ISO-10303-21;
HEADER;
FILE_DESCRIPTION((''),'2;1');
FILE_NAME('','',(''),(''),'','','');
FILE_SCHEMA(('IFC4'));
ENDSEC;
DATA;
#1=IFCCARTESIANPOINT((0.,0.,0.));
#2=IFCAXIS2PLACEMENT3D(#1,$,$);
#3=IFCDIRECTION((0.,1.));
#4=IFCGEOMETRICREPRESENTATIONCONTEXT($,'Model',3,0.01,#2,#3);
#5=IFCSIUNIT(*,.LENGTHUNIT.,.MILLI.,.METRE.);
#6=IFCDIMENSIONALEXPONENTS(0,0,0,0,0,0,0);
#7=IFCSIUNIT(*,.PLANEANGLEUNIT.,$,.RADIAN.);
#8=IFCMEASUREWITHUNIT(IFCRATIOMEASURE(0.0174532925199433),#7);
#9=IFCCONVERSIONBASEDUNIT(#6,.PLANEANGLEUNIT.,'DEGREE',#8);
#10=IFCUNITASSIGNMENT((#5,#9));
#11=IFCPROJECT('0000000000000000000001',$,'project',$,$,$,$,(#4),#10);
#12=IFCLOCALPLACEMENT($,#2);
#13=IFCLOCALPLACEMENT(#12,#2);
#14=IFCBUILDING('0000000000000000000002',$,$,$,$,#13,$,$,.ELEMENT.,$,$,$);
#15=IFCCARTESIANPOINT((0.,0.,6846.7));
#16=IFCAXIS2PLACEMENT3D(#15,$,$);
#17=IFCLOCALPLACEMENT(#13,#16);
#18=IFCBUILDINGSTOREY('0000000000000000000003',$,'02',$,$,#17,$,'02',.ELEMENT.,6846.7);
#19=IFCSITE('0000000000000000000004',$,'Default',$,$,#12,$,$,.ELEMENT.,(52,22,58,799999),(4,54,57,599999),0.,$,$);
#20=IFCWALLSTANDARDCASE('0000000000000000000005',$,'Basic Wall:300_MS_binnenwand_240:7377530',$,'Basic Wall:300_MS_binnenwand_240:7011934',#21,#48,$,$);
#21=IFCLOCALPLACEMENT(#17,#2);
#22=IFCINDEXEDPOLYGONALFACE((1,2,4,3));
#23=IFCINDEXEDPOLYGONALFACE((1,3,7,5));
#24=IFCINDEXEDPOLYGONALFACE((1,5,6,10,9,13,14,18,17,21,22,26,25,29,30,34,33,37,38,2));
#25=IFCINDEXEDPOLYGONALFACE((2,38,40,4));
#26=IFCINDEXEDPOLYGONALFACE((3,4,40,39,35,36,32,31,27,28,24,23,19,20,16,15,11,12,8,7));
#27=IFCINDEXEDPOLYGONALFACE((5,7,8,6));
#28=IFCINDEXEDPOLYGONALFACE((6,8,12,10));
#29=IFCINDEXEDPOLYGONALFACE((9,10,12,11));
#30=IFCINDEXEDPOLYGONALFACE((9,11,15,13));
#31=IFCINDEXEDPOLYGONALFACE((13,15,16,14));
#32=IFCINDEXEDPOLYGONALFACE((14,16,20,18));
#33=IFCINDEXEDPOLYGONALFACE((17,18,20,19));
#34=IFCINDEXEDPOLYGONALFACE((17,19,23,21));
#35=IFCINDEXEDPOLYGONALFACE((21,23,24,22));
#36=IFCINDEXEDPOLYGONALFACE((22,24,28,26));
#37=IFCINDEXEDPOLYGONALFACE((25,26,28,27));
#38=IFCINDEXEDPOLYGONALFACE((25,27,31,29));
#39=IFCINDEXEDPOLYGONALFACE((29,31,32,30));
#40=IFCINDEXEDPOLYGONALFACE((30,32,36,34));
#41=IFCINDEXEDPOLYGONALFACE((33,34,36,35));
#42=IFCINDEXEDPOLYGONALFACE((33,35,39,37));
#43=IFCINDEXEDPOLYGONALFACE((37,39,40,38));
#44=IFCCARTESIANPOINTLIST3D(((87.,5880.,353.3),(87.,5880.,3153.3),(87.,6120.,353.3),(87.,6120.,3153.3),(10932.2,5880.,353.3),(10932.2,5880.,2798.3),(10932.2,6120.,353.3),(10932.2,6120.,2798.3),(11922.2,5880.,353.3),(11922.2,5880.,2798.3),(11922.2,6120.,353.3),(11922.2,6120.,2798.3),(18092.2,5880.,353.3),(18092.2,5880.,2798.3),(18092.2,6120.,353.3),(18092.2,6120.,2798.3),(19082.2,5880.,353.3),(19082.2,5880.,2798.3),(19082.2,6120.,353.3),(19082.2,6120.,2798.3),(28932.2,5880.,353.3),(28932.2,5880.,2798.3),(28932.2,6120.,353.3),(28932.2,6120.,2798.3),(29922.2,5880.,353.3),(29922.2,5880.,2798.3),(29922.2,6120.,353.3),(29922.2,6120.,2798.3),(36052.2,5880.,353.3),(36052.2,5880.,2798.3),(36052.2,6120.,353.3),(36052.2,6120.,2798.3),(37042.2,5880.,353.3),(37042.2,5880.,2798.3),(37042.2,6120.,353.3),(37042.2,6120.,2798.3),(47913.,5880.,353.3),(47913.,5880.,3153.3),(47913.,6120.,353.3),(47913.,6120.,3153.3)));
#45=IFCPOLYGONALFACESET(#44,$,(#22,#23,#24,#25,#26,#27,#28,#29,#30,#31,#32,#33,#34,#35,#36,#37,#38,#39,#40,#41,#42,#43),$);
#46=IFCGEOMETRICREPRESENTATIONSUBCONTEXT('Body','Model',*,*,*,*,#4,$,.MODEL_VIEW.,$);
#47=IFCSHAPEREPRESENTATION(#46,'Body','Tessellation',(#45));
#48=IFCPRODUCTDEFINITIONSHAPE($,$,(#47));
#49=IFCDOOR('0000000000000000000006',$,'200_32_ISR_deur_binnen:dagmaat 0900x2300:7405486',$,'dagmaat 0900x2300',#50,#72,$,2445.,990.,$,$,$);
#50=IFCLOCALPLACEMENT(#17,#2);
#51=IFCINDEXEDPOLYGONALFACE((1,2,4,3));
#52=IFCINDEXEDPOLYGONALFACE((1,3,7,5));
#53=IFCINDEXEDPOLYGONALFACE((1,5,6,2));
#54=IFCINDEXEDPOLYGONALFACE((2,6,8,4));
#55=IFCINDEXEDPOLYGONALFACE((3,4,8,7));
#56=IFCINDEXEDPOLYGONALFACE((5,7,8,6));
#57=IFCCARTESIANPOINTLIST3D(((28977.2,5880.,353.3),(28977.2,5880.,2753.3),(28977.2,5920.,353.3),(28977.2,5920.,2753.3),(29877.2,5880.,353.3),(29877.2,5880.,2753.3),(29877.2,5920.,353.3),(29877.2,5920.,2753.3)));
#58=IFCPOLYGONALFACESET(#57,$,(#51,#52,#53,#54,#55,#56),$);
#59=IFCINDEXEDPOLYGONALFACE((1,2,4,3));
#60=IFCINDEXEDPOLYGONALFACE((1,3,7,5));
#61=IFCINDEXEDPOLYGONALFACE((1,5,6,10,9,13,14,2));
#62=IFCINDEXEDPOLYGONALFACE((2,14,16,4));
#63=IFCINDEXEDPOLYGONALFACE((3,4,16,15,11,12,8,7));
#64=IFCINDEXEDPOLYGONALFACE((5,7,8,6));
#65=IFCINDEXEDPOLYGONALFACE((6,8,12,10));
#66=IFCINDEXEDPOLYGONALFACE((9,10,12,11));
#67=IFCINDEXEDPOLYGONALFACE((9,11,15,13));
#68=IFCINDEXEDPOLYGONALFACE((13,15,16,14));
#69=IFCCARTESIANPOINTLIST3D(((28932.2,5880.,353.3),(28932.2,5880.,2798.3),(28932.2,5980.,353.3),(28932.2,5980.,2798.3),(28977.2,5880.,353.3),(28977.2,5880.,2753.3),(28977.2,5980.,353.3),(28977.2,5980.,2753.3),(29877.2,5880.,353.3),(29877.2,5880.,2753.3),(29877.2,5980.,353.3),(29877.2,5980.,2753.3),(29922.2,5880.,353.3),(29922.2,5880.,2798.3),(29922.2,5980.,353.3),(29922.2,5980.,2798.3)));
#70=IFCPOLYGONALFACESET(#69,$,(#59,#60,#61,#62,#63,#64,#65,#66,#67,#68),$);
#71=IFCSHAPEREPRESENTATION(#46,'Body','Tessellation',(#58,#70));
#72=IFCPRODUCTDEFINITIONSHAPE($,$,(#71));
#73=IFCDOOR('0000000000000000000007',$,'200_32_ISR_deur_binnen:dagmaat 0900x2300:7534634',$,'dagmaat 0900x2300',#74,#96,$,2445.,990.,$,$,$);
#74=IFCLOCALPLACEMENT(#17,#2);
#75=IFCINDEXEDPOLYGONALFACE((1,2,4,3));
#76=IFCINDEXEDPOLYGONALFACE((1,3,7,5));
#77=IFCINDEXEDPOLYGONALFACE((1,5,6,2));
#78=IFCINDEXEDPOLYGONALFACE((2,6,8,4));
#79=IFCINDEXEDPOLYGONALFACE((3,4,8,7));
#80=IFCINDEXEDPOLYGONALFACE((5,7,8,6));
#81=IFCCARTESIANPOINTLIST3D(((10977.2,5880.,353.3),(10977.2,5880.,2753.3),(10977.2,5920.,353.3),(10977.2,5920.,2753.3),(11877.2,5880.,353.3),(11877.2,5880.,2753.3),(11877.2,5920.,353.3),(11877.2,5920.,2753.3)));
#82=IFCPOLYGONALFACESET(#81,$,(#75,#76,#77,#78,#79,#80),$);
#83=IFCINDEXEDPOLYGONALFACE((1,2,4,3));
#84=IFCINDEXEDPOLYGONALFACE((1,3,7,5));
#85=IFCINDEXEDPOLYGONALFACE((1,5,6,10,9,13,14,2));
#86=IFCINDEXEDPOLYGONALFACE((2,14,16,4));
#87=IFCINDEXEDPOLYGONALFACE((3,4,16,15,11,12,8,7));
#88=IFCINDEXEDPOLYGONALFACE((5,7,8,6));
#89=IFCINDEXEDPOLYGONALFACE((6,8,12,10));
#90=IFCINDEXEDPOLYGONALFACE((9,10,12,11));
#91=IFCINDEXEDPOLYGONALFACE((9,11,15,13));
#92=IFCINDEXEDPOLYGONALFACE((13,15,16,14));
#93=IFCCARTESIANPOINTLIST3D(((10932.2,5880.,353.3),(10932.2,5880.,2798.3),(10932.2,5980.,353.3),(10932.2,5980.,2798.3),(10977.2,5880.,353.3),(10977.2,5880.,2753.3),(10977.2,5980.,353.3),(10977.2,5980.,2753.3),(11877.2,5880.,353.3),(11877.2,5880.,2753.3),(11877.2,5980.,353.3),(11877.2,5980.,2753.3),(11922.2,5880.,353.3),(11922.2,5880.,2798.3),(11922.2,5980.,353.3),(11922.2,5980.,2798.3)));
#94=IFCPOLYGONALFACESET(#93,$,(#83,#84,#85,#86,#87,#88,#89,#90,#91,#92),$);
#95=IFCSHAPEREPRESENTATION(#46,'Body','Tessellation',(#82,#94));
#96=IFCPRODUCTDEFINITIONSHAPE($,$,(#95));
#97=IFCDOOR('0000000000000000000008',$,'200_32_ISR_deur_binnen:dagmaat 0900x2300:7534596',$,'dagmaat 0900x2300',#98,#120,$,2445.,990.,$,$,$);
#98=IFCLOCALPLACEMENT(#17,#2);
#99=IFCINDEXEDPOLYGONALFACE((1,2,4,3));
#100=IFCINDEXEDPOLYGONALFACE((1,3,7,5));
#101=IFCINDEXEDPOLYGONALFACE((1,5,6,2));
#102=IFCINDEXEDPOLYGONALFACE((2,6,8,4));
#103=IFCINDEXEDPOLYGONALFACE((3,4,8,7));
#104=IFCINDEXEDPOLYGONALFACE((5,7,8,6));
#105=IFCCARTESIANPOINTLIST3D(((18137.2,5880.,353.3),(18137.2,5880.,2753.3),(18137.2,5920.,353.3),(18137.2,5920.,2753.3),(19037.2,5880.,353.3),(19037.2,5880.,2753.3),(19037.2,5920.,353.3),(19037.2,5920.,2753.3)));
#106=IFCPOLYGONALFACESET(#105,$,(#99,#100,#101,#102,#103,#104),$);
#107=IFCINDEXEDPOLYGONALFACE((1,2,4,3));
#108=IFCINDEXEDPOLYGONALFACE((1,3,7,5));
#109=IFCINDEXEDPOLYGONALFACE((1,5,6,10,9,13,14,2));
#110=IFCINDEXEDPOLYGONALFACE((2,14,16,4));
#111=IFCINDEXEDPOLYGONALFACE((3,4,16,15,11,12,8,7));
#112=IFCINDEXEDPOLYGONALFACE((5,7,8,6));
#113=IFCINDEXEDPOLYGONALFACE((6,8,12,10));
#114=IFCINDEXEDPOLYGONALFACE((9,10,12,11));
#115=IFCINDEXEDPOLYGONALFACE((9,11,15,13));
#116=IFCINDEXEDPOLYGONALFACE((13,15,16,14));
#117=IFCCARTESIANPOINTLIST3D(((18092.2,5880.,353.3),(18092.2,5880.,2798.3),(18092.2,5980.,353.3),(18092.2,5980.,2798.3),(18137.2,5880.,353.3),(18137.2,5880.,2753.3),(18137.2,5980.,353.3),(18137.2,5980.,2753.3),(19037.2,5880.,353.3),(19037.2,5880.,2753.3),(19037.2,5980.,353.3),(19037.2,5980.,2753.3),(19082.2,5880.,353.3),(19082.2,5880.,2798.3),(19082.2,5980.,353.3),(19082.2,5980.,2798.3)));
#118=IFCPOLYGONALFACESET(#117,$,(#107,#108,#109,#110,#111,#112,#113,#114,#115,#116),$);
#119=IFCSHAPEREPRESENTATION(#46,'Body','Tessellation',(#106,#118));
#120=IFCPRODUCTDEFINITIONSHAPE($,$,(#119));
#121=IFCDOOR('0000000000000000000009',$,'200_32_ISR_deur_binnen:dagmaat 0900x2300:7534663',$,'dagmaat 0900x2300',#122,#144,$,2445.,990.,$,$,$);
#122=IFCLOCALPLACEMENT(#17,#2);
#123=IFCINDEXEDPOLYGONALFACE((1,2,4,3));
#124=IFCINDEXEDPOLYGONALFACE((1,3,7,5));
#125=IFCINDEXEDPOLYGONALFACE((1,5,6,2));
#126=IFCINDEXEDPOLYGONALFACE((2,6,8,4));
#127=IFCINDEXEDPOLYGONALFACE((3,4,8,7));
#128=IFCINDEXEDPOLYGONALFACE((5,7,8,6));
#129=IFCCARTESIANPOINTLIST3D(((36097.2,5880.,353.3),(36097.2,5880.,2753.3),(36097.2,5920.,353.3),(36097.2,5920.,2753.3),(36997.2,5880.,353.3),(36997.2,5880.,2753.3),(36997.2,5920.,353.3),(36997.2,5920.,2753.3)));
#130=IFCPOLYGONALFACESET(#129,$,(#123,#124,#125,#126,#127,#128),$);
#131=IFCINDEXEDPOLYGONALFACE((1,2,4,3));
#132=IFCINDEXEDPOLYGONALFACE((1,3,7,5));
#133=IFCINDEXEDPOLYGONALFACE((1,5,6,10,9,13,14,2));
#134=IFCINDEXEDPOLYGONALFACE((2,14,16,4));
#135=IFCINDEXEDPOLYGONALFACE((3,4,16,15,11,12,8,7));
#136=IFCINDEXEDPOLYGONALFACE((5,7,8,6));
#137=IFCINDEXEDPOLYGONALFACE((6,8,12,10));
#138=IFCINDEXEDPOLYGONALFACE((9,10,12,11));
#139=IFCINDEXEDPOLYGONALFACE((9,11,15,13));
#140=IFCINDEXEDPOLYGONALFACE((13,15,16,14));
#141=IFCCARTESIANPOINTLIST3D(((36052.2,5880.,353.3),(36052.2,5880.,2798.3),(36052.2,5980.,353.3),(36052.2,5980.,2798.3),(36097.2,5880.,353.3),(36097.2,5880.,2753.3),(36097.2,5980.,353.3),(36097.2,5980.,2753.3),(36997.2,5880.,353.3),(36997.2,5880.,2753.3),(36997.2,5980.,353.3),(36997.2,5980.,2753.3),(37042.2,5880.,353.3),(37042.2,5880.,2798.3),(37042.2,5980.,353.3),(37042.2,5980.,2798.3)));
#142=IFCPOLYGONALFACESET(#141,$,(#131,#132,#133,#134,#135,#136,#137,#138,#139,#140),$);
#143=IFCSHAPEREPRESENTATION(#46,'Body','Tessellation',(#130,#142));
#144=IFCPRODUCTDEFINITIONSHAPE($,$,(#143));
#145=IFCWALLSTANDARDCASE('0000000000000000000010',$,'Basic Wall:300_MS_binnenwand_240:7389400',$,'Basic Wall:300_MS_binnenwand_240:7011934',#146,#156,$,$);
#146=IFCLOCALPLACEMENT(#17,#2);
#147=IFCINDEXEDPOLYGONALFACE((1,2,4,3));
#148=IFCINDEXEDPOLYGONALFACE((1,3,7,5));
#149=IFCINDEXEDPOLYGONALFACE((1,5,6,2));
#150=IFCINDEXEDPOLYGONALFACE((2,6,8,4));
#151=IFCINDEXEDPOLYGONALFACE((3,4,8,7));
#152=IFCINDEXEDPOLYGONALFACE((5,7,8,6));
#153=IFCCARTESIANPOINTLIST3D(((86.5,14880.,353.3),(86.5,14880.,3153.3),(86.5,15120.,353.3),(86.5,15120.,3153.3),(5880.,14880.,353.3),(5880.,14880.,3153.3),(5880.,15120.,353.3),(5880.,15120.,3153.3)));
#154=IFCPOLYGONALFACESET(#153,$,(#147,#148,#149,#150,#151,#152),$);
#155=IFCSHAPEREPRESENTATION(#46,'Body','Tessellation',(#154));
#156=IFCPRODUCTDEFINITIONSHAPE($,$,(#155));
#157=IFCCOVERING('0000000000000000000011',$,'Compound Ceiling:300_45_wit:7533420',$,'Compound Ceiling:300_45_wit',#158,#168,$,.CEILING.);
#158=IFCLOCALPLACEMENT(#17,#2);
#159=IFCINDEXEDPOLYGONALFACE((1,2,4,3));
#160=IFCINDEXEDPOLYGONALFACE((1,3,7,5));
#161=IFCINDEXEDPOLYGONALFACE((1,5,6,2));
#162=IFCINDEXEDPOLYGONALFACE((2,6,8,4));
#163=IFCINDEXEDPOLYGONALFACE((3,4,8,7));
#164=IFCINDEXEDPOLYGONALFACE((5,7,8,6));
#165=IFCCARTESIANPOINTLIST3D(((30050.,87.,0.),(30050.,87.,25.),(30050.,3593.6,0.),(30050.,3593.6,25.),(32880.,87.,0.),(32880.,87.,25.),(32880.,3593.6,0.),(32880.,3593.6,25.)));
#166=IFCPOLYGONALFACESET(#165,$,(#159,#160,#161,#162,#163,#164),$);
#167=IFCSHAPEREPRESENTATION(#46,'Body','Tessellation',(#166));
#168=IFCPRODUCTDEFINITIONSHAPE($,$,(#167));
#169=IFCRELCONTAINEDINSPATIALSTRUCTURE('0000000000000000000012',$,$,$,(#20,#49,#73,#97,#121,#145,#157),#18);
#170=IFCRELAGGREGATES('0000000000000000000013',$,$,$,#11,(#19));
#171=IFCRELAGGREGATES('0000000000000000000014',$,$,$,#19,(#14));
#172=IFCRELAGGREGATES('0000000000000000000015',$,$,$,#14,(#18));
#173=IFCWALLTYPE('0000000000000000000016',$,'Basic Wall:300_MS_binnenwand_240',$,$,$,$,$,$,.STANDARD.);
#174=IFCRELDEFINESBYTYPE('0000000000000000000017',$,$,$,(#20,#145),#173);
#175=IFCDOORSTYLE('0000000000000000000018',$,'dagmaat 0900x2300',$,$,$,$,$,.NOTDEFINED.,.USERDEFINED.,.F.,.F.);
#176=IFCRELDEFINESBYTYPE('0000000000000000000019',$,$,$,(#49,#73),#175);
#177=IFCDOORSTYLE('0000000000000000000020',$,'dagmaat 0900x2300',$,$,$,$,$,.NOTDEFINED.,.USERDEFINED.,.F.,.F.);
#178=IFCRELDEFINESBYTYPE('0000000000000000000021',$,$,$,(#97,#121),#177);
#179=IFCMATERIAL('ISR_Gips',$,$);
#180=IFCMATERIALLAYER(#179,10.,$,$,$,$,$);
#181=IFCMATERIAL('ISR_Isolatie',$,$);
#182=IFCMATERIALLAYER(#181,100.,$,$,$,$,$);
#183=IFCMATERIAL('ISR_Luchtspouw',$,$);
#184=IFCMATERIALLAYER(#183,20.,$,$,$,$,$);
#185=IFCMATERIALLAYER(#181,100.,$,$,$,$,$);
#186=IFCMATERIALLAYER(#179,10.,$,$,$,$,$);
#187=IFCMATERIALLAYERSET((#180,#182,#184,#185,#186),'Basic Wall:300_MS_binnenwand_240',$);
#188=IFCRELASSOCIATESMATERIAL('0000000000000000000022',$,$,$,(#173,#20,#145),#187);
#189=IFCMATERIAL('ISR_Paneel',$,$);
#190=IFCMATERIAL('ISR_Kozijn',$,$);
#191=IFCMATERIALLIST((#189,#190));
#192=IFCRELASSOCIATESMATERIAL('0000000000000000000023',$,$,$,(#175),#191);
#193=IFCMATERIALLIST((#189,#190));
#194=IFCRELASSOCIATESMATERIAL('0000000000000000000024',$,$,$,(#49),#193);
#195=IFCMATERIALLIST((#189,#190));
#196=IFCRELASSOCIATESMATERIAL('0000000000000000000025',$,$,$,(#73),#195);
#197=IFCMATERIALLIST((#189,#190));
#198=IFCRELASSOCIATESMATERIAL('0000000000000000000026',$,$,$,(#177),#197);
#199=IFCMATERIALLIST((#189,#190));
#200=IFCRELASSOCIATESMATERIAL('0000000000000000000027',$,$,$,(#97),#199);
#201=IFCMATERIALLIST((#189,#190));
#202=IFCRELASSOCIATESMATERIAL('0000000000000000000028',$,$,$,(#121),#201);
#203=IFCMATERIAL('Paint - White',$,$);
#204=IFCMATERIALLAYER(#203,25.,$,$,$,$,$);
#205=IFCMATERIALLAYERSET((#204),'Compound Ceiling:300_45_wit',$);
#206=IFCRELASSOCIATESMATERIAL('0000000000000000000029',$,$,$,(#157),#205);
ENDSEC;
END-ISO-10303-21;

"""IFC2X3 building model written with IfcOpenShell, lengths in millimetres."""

from ifc_helpers import new_model, entity, si_unit, converted_unit, direction, frame, frame_2d, origin, origin_2d_with_axis, place, context, subcontext, project, spatial, polyline, rectangle, outline, extrude, source, transform, mapped, material, material_list, layer, layer_set, layer_usage, type_object, type_shapes, element, fill, save


model = new_model("IFC2X3")

# Units and contexts
model_context = context("Model", 3, precision=0.01, world=origin(), true_north=direction((0.0, 1.0)))
body_context = subcontext(model_context, "Body", "Model", "MODEL_VIEW")
ifc_project = project(units=[si_unit("LENGTHUNIT", "METRE", prefix="MILLI"), converted_unit("PLANEANGLEUNIT", "DEGREE", entity("IfcRatioMeasure", 0.0174532925199433), si_unit("PLANEANGLEUNIT", "RADIAN"), dimensions=[0, 0, 0, 0, 0, 0, 0])], contexts=[model_context])

# Site, building, storey
site_placement = place(None, origin())
site = spatial("IfcSite", under=ifc_project, at=site_placement, Name="Default", CompositionType="ELEMENT", RefLatitude=(52, 22, 58, 799999), RefLongitude=(4, 54, 57, 599999), RefElevation=0.0)
building_placement = place(site_placement, origin())
building = spatial("IfcBuilding", under=site, at=building_placement, CompositionType="ELEMENT")
storey_placement = place(building_placement, frame((0.0, 0.0, 6846.7)))
storey = spatial("IfcBuildingStorey", under=building, at=storey_placement, Name="02", LongName="02", CompositionType="ELEMENT", Elevation=6846.7)

# Shared definitions
ifc_material_1 = material(Name="ISR_Gips")
ifc_material_2 = material(Name="ISR_Isolatie")

# Wall, openings, doors
ifc_layer_1 = layer(ifc_material_1, 10.0)
ifc_layer_2 = layer(ifc_material_2, 100.0)
ifc_material_3 = material(Name="ISR_Luchtspouw")
ifc_layer_3 = layer(ifc_material_3, 20.0)
ifc_layer_4 = layer(ifc_material_2, 100.0)
ifc_layer_5 = layer(ifc_material_1, 10.0)
ifc_layer_set_1 = layer_set([ifc_layer_1, ifc_layer_2, ifc_layer_3, ifc_layer_4, ifc_layer_5], Name="Basic Wall:300_MS_binnenwand_240")
ifc_layer_usage_1 = layer_usage(ifc_layer_set_1, "AXIS2", "NEGATIVE", 120.0)
wall_type_1 = type_object("IfcWallType", Name="Basic Wall:300_MS_binnenwand_240", PredefinedType="STANDARD", material=ifc_layer_set_1)
wall_1_placement = place(storey_placement, frame((87.0, 6000.0, 353.3)))
wall_1 = element("IfcWallStandardCase", 1, at=wall_1_placement, inside=storey, type_object=wall_type_1, material=ifc_layer_usage_1, Name="Basic Wall:300_MS_binnenwand_240:7377530", ObjectType="Basic Wall:300_MS_binnenwand_240:7011934", context=body_context, shape_type="SweptSolid", body=[
    extrude(rectangle(XDim=47826.0, YDim=240.0, at=frame_2d((23913.0, 0.0), x_axis=(-1.0, 0.0))), origin(), (0.0, 0.0, 1.0), 2800.0),
])
opening_1_placement = place(wall_1_placement, frame((29835.2, 120.0, 0.0)))
opening_1 = element("IfcOpeningElement", 2, at=opening_1_placement, cuts=wall_1, ObjectType="Opening", context=body_context, shape_type="SweptSolid", body=[
    extrude(rectangle(XDim=2445.0, YDim=990.0, at=frame_2d((1222.5, 495.0), x_axis=(-1.0, 0.0))), frame((0.0, 0.0, 0.0), z_axis=(0.0, -1.0, 0.0), x_axis=(0.0, 0.0, 1.0)), (0.0, 0.0, 1.0), 240.0),
])
opening_2_placement = place(wall_1_placement, frame((18995.2, 120.0, 0.0)))
opening_2 = element("IfcOpeningElement", 3, at=opening_2_placement, cuts=wall_1, ObjectType="Opening", context=body_context, shape_type="SweptSolid", body=[
    extrude(rectangle(XDim=2445.0, YDim=990.0, at=frame_2d((1222.5, 495.0), x_axis=(-1.0, 0.0))), frame((0.0, 0.0, 0.0), z_axis=(0.0, -1.0, 0.0), x_axis=(0.0, 0.0, 1.0)), (0.0, 0.0, 1.0), 240.0),
])
opening_3_placement = place(wall_1_placement, frame((11835.2, 120.0, 0.0)))
opening_3 = element("IfcOpeningElement", 4, at=opening_3_placement, cuts=wall_1, ObjectType="Opening", context=body_context, shape_type="SweptSolid", body=[
    extrude(rectangle(XDim=2445.0, YDim=990.0, at=frame_2d((1222.5, 495.0), x_axis=(-1.0, 0.0))), frame((0.0, 0.0, 0.0), z_axis=(0.0, -1.0, 0.0), x_axis=(0.0, 0.0, 1.0)), (0.0, 0.0, 1.0), 240.0),
])
opening_4_placement = place(wall_1_placement, frame((36955.2, 120.0, 0.0)))
opening_4 = element("IfcOpeningElement", 5, at=opening_4_placement, cuts=wall_1, ObjectType="Opening", context=body_context, shape_type="SweptSolid", body=[
    extrude(rectangle(XDim=2445.0, YDim=990.0, at=frame_2d((1222.5, 495.0), x_axis=(-1.0, 0.0))), frame((0.0, 0.0, 0.0), z_axis=(0.0, -1.0, 0.0), x_axis=(0.0, 0.0, 1.0)), (0.0, 0.0, 1.0), 240.0),
])
ifc_material_4 = material(Name="ISR_Paneel")
ifc_material_5 = material(Name="ISR_Kozijn")
ifc_material_list_1 = material_list([ifc_material_4, ifc_material_5])
ifc_material_list_2 = material_list([ifc_material_4, ifc_material_5])
door_style_1 = type_object("IfcDoorStyle", Name="dagmaat 0900x2300", ConstructionType="USERDEFINED", OperationType="NOTDEFINED", ParameterTakesPrecedence=False, Sizeable=False, material=ifc_material_list_2)
shared_shape_1 = source(origin(), body_context, "Body", "SweptSolid", [
    extrude(rectangle(XDim=900.0, YDim=40.0, at=origin_2d_with_axis()), frame((495.0, 220.0, 0.0)), (0.0, 0.0, 1.0), 2400.0),
    extrude(outline(polyline([(-1211.2, -450.0), (-1211.2, -495.0), (1233.7, -495.0), (1233.7, 495.0), (-1211.2, 495.0), (-1211.2, 450.0), (1188.8, 450.0), (1188.8, -450.0), (-1211.2, -450.0)])), frame((495.0, 140.0, 1211.2), z_axis=(0.0, -1.0, 0.0), x_axis=(0.0, 0.0, 1.0)), (0.0, 0.0, -1.0), 100.0),
])
type_shapes(door_style_1, [shared_shape_1])
door_1_placement = place(opening_1_placement, frame((0.0, 0.0, 0.0), z_axis=(0.0, 0.0, 1.0), x_axis=(-1.0, 0.0, 0.0)))
door_1 = element("IfcDoor", 6, at=door_1_placement, inside=storey, type_object=door_style_1, material=ifc_material_list_1, Name="200_32_ISR_deur_binnen:dagmaat 0900x2300:7405486", ObjectType="dagmaat 0900x2300", OverallHeight=2445.0, OverallWidth=990.0, context=body_context, shape_type="MappedRepresentation", body=[
    mapped(shared_shape_1, transform((0.0, 0.0, 0.0), scale=1.0)),
])
fill(opening_1, door_1)
ifc_material_list_3 = material_list([ifc_material_4, ifc_material_5])
door_2_placement = place(opening_3_placement, frame((0.0, 0.0, 0.0), z_axis=(0.0, 0.0, 1.0), x_axis=(-1.0, 0.0, 0.0)))
door_2 = element("IfcDoor", 7, at=door_2_placement, inside=storey, type_object=door_style_1, material=ifc_material_list_3, Name="200_32_ISR_deur_binnen:dagmaat 0900x2300:7534634", ObjectType="dagmaat 0900x2300", OverallHeight=2445.0, OverallWidth=990.0, context=body_context, shape_type="MappedRepresentation", body=[
    mapped(shared_shape_1, transform((0.0, 0.0, 0.0), scale=1.0)),
])
fill(opening_3, door_2)
ifc_material_list_4 = material_list([ifc_material_4, ifc_material_5])
ifc_material_list_5 = material_list([ifc_material_4, ifc_material_5])
door_style_2 = type_object("IfcDoorStyle", Name="dagmaat 0900x2300", ConstructionType="USERDEFINED", OperationType="NOTDEFINED", ParameterTakesPrecedence=False, Sizeable=False, material=ifc_material_list_5)
shared_shape_2 = source(origin(), body_context, "Body", "SweptSolid", [
    extrude(rectangle(XDim=40.0, YDim=900.0, at=frame_2d((0.0, 0.0), x_axis=(1.0, 0.0))), frame((495.0, 220.0, 0.0), z_axis=(0.0, 0.0, 1.0), x_axis=(0.0, 1.0, 0.0)), (0.0, 0.0, 1.0), 2400.0),
    extrude(outline(polyline([(-1211.2, -450.0), (-1211.2, -495.0), (1233.7, -495.0), (1233.7, 495.0), (-1211.2, 495.0), (-1211.2, 450.0), (1188.8, 450.0), (1188.8, -450.0), (-1211.2, -450.0)])), frame((495.0, 240.0, 1211.2), z_axis=(0.0, 1.0, 0.0), x_axis=(0.0, 0.0, 1.0)), (0.0, 0.0, -1.0), 100.0),
])
type_shapes(door_style_2, [shared_shape_2])
door_3_placement = place(opening_2_placement, frame((0.0, 0.0, 0.0), z_axis=(0.0, 0.0, 1.0), x_axis=(-1.0, 0.0, 0.0)))
door_3 = element("IfcDoor", 8, at=door_3_placement, inside=storey, type_object=door_style_2, material=ifc_material_list_4, Name="200_32_ISR_deur_binnen:dagmaat 0900x2300:7534596", ObjectType="dagmaat 0900x2300", OverallHeight=2445.0, OverallWidth=990.0, context=body_context, shape_type="MappedRepresentation", body=[
    mapped(shared_shape_2, transform((0.0, 0.0, 0.0), scale=1.0)),
])
fill(opening_2, door_3)
ifc_material_list_6 = material_list([ifc_material_4, ifc_material_5])
door_4_placement = place(opening_4_placement, frame((0.0, 0.0, 0.0), z_axis=(0.0, 0.0, 1.0), x_axis=(-1.0, 0.0, 0.0)))
door_4 = element("IfcDoor", 9, at=door_4_placement, inside=storey, type_object=door_style_2, material=ifc_material_list_6, Name="200_32_ISR_deur_binnen:dagmaat 0900x2300:7534663", ObjectType="dagmaat 0900x2300", OverallHeight=2445.0, OverallWidth=990.0, context=body_context, shape_type="MappedRepresentation", body=[
    mapped(shared_shape_2, transform((0.0, 0.0, 0.0), scale=1.0)),
])
fill(opening_4, door_4)

# Wall
ifc_layer_usage_2 = layer_usage(ifc_layer_set_1, "AXIS2", "NEGATIVE", 120.0)
wall_2_placement = place(storey_placement, frame((5880.0, 15000.0, 353.3), z_axis=(0.0, 0.0, 1.0), x_axis=(-1.0, 0.0, 0.0)))
element("IfcWallStandardCase", 10, at=wall_2_placement, inside=storey, type_object=wall_type_1, material=ifc_layer_usage_2, Name="Basic Wall:300_MS_binnenwand_240:7389400", ObjectType="Basic Wall:300_MS_binnenwand_240:7011934", context=body_context, shape_type="SweptSolid", body=[
    extrude(rectangle(XDim=5793.5, YDim=240.0, at=frame_2d((2896.8, 0.0), x_axis=(-1.0, 0.0))), origin(), (0.0, 0.0, 1.0), 2800.0),
])

# Covering
ifc_material_6 = material(Name="Paint - White")
ifc_layer_6 = layer(ifc_material_6, 25.0)
ifc_layer_set_2 = layer_set([ifc_layer_6], Name="Compound Ceiling:300_45_wit")
ifc_layer_usage_3 = layer_usage(ifc_layer_set_2, "AXIS3", "NEGATIVE", 0.0)
covering_1_placement = place(storey_placement, origin())
element("IfcCovering", 11, at=covering_1_placement, inside=storey, material=ifc_layer_usage_3, Name="Compound Ceiling:300_45_wit:7533420", ObjectType="Compound Ceiling:300_45_wit", PredefinedType="CEILING", context=body_context, shape_type="SweptSolid", body=[
    extrude(rectangle(XDim=2830.0, YDim=3506.6, at=origin_2d_with_axis()), frame((31465.0, 1840.3, 0.0), z_axis=(0.0, 0.0, 1.0), x_axis=(-1.0, 0.0, 0.0)), (0.0, 0.0, 1.0), 25.0),
])

save(model, "model.ifc")
